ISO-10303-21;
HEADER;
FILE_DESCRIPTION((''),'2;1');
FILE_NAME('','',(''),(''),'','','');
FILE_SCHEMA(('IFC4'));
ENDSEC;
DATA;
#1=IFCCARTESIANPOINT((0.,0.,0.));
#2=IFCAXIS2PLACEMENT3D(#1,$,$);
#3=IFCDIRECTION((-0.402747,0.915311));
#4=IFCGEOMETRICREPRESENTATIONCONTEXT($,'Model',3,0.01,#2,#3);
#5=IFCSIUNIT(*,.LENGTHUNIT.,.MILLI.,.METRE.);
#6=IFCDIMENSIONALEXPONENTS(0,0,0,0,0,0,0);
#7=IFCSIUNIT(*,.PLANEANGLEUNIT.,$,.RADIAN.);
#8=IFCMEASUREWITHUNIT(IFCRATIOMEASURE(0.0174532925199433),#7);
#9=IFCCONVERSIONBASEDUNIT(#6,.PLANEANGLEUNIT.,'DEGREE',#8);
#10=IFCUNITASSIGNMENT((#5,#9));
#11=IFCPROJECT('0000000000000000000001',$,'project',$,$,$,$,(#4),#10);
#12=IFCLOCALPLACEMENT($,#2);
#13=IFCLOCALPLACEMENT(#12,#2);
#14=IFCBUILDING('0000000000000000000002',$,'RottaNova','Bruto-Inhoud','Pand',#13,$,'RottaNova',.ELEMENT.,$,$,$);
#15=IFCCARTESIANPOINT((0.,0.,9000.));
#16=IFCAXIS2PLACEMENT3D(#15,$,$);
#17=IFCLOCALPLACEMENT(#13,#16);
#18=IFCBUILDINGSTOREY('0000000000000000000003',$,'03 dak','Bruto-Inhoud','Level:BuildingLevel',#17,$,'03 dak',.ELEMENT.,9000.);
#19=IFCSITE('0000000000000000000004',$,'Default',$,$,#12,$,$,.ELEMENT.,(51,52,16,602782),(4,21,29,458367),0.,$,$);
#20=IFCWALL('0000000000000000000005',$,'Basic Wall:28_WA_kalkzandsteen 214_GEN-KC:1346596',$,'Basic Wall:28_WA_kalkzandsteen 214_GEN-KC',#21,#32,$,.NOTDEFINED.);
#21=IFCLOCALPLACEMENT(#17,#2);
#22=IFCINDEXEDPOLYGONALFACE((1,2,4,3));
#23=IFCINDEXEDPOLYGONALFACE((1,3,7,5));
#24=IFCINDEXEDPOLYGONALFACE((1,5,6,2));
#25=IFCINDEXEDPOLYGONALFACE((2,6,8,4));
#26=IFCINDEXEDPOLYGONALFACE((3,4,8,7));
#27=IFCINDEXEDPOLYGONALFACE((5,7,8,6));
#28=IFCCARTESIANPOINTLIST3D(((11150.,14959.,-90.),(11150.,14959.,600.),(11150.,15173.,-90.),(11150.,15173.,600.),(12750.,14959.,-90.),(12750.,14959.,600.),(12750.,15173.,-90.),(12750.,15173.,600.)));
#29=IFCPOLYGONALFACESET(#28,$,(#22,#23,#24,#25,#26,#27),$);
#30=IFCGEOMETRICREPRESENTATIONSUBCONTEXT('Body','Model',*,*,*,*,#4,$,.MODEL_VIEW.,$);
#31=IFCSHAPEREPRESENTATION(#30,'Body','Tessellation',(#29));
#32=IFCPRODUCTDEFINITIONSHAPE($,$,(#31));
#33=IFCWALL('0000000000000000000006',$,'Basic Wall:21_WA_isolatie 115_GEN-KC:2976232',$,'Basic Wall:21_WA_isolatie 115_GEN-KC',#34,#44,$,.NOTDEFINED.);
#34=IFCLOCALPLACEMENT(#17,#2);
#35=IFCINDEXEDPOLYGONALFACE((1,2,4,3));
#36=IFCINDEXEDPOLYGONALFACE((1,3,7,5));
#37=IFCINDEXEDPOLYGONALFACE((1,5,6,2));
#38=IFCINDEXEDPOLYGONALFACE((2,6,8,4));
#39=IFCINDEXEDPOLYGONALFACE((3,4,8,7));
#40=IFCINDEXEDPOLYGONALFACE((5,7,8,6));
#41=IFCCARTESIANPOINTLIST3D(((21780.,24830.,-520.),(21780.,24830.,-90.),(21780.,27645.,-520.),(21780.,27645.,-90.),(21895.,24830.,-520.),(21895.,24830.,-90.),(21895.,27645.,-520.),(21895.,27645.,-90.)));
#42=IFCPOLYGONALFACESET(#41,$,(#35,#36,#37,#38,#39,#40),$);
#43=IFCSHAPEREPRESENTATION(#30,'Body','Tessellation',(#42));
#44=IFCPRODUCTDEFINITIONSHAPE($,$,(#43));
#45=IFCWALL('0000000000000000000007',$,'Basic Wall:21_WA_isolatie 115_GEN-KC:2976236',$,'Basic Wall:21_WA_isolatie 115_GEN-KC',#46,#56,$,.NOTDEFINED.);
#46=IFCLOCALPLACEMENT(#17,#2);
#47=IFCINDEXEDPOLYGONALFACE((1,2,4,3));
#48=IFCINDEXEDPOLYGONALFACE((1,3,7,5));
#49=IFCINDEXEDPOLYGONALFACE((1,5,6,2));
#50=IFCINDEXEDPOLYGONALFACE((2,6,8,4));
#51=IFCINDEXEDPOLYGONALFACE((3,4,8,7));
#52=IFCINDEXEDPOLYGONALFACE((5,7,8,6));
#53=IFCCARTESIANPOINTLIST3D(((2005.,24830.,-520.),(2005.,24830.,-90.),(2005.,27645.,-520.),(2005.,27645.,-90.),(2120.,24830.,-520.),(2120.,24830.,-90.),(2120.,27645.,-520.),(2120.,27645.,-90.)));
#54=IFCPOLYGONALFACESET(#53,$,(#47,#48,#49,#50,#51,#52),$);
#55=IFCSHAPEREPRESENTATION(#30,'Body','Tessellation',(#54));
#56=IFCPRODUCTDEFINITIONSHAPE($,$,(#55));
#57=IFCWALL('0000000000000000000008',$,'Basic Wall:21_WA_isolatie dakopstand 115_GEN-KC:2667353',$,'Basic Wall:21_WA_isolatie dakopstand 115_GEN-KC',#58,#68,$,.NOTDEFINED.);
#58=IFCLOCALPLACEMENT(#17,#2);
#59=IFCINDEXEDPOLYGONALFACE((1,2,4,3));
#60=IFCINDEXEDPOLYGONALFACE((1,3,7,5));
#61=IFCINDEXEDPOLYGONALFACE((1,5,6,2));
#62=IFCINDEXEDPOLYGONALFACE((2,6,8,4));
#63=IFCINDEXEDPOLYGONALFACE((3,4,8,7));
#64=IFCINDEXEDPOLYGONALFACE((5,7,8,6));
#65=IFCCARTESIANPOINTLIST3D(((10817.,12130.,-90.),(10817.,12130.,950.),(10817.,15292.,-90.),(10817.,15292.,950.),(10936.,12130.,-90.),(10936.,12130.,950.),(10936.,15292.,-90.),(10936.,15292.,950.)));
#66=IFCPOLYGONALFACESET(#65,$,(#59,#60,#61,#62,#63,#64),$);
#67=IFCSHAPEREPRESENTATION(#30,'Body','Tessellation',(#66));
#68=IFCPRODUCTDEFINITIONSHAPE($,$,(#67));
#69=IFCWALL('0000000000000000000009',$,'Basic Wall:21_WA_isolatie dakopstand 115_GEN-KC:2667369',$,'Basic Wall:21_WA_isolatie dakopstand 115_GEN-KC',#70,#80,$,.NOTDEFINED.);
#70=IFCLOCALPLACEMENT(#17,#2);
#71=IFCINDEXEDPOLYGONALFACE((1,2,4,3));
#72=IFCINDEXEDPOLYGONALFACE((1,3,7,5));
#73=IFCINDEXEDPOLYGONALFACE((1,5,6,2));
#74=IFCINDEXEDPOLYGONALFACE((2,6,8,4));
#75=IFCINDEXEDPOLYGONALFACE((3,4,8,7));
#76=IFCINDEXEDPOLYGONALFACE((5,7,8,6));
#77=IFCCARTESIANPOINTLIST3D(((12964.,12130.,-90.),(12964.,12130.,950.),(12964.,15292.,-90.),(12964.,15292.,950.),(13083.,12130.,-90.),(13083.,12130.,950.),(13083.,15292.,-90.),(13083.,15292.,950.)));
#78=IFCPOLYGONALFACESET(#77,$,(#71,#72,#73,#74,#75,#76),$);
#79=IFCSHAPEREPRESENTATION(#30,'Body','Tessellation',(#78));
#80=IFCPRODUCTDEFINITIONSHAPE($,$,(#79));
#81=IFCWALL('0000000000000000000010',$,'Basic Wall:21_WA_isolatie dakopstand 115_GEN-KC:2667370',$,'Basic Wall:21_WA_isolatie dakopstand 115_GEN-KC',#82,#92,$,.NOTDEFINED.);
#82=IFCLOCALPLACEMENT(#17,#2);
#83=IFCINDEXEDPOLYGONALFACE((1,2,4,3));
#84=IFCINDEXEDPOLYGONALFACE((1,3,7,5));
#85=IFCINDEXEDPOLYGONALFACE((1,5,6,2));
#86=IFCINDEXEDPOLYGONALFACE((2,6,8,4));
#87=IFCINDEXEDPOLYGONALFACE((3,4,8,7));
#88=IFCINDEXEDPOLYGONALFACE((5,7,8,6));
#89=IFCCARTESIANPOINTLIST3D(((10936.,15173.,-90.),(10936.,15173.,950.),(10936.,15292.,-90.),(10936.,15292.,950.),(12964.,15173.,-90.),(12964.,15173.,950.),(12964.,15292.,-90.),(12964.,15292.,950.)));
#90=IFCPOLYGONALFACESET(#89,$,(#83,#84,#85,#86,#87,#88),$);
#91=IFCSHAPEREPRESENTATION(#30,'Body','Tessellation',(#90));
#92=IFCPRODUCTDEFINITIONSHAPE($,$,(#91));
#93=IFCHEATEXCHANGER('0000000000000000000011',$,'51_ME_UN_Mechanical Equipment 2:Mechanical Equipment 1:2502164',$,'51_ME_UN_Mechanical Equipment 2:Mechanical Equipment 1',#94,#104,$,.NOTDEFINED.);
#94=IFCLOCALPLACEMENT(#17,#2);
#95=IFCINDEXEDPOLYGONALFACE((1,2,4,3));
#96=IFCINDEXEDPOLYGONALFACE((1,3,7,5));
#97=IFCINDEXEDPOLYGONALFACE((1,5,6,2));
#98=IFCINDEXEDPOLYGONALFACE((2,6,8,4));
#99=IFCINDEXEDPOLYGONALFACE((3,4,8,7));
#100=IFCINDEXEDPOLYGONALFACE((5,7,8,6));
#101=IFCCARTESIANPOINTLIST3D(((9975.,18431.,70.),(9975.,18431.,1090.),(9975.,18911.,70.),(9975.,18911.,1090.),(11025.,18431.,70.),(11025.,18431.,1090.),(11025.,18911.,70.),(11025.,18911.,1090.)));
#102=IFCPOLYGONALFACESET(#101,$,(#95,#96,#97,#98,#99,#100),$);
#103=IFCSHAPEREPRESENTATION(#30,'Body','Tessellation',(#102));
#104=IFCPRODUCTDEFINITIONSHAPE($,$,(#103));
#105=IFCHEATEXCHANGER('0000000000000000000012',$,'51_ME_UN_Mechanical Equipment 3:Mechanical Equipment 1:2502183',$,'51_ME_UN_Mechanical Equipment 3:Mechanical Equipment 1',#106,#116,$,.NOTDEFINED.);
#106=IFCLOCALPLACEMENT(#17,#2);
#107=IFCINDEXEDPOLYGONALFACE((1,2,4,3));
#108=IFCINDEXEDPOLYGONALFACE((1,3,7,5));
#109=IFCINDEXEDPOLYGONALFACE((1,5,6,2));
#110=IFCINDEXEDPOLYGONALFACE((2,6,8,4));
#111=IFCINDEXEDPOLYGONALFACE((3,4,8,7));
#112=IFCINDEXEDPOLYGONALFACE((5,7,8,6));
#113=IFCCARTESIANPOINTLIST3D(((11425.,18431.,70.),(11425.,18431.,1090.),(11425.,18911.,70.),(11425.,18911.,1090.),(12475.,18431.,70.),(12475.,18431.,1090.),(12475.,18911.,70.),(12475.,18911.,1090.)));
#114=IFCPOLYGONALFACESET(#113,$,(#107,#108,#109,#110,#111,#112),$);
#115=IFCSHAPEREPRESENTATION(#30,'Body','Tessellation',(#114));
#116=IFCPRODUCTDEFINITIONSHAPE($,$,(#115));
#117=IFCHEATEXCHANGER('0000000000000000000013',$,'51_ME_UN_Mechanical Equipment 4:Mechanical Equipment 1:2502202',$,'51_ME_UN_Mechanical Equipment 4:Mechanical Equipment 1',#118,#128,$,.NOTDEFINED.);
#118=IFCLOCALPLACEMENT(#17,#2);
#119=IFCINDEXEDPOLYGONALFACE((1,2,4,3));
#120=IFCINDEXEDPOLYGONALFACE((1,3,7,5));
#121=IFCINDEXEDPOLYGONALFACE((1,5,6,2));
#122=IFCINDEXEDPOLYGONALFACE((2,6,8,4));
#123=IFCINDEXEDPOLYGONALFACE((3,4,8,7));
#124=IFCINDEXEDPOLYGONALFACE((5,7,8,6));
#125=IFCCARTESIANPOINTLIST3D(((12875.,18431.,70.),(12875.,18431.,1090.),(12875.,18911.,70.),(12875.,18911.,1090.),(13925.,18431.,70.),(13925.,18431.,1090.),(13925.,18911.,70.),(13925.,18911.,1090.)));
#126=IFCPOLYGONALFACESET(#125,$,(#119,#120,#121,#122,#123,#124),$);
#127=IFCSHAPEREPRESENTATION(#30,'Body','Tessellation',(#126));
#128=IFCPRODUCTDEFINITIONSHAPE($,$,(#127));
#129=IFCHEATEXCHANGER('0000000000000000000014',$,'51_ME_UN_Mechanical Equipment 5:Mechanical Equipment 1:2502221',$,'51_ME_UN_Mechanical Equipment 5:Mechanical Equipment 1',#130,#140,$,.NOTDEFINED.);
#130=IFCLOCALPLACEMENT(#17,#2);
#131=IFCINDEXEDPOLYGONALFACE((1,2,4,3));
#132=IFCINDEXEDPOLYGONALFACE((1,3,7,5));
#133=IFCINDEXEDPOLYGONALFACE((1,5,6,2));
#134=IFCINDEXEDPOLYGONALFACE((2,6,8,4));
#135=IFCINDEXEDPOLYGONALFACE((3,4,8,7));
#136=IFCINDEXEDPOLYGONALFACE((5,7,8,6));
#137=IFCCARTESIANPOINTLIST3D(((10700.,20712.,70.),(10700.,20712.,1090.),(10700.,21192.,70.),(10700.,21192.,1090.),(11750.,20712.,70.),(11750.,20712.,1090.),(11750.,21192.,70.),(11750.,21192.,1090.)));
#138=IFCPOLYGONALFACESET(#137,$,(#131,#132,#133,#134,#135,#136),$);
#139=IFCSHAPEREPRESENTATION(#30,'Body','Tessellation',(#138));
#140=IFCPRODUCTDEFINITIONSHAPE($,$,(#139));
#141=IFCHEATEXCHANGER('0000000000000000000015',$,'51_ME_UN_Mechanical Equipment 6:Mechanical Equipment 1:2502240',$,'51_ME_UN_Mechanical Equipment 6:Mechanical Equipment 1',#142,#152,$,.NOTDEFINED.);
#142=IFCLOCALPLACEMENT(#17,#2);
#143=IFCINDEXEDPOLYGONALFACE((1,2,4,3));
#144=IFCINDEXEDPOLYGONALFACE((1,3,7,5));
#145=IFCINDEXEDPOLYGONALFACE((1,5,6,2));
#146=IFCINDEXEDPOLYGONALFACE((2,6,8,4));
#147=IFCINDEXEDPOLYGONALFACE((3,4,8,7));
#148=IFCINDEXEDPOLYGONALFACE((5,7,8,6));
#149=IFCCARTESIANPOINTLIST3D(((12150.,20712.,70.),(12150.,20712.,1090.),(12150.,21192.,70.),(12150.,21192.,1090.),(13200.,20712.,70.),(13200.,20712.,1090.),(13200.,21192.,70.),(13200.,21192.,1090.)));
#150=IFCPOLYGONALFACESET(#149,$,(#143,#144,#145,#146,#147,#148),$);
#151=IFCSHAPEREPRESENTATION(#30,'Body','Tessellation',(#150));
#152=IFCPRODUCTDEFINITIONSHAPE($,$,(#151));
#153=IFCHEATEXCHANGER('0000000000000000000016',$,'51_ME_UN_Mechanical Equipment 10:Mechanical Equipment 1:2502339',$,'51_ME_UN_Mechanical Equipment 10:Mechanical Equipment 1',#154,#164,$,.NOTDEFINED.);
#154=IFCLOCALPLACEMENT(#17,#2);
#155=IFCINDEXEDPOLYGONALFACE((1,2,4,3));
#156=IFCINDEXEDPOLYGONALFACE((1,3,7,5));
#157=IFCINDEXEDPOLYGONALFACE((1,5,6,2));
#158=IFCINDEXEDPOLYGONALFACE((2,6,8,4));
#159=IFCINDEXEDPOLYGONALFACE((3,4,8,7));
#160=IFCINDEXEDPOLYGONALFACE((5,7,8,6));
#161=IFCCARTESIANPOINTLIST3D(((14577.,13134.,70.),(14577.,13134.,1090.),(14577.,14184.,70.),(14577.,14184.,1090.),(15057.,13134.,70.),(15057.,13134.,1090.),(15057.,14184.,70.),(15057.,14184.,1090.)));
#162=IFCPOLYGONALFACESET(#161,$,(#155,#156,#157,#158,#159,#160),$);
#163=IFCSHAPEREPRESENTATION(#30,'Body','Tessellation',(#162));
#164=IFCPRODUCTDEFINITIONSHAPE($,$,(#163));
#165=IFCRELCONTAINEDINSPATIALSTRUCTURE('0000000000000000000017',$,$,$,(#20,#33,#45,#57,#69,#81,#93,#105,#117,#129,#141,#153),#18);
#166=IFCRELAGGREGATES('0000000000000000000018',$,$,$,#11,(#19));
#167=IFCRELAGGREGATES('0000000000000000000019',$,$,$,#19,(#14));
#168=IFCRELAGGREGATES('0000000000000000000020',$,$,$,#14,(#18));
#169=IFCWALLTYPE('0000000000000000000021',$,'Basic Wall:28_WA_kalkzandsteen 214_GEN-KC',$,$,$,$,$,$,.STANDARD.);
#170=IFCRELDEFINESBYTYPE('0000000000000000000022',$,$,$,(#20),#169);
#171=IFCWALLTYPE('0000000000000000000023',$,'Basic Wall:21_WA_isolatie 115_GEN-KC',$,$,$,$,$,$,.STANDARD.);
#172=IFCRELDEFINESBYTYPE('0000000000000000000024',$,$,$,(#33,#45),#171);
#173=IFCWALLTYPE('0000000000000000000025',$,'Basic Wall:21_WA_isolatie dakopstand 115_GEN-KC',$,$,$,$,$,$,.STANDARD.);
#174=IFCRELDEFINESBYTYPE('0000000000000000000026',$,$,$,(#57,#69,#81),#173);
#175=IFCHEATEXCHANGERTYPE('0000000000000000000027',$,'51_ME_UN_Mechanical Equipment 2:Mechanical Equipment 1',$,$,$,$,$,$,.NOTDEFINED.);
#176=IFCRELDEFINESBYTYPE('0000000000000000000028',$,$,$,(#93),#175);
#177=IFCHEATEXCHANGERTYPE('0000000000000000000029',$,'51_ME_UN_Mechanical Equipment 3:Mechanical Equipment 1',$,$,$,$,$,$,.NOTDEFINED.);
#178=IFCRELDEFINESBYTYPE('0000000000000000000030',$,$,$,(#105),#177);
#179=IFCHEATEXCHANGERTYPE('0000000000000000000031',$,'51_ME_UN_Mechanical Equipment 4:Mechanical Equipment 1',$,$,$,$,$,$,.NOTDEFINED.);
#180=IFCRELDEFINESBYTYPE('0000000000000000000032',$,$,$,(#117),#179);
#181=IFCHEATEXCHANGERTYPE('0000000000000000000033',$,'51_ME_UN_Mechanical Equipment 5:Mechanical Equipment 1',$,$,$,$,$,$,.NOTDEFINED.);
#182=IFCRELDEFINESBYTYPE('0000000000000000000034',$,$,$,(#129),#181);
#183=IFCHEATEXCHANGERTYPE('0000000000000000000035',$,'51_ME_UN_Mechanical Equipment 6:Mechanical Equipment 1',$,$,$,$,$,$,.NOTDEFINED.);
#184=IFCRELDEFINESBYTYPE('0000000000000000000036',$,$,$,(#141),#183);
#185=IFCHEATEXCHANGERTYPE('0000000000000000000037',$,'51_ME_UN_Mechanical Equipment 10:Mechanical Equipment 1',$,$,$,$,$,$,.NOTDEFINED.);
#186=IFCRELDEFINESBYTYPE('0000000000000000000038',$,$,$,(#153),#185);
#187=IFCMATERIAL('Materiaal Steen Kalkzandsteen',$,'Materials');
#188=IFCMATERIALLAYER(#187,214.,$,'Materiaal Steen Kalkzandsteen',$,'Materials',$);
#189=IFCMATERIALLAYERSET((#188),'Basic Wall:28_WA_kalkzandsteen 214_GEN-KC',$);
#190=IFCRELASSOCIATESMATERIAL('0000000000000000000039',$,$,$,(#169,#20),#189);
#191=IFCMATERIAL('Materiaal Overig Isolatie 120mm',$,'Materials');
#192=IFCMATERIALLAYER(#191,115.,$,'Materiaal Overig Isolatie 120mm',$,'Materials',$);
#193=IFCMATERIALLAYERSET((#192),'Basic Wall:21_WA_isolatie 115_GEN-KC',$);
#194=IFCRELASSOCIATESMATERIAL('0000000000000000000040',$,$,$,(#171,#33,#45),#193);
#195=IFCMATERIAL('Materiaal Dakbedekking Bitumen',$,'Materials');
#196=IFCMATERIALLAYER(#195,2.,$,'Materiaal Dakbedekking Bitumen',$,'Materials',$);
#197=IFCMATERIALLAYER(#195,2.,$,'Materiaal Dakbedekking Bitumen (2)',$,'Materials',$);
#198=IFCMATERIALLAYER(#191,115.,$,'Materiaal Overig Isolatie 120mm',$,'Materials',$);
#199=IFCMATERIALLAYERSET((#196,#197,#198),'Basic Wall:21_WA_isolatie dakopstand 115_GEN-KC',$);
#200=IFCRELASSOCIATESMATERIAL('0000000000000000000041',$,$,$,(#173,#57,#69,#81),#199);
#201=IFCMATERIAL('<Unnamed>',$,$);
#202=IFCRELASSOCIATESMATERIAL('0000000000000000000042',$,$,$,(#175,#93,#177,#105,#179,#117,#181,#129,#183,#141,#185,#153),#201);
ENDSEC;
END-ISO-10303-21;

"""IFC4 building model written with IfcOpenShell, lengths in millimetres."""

from ifc_helpers import new_model, entity, si_unit, converted_unit, direction, frame, frame_2d, origin, place, context, subcontext, project, spatial, rectangle, extrude, source, transform, mapped, material, layer, layer_set, type_object, type_shapes, element, save


model = new_model("IFC4")

# Units and contexts
model_context = context("Model", 3, precision=0.01, world=origin(), true_north=direction((-0.402747, 0.915311)))
body_context = subcontext(model_context, "Body", "Model", "MODEL_VIEW")
ifc_project = project(units=[si_unit("LENGTHUNIT", "METRE", prefix="MILLI"), converted_unit("PLANEANGLEUNIT", "DEGREE", entity("IfcRatioMeasure", 0.0174532925199433), si_unit("PLANEANGLEUNIT", "RADIAN"), dimensions=[0, 0, 0, 0, 0, 0, 0])], contexts=[model_context])

# Site, building, storey
site_placement = place(None, origin())
site = spatial("IfcSite", under=ifc_project, at=site_placement, Name="Default", CompositionType="ELEMENT", RefLatitude=(51, 52, 16, 602782), RefLongitude=(4, 21, 29, 458367), RefElevation=0.0)
building_placement = place(site_placement, origin())
building = spatial("IfcBuilding", under=site, at=building_placement, Name="RottaNova", Description="Bruto-Inhoud", ObjectType="Pand", LongName="RottaNova", CompositionType="ELEMENT")
storey_placement = place(building_placement, frame((0.0, 0.0, 9000.0)))
storey = spatial("IfcBuildingStorey", under=building, at=storey_placement, Name="03 dak", Description="Bruto-Inhoud", ObjectType="Level:BuildingLevel", LongName="03 dak", CompositionType="ELEMENT", Elevation=9000.0)

# Wall
ifc_material_1 = material(Name="Materiaal Steen Kalkzandsteen", Category="Materials")
ifc_layer_1 = layer(ifc_material_1, 214.0, Name="Materiaal Steen Kalkzandsteen", Category="Materials")
ifc_layer_set_1 = layer_set([ifc_layer_1], Name="Basic Wall:28_WA_kalkzandsteen 214_GEN-KC")
wall_type_1 = type_object("IfcWallType", Name="Basic Wall:28_WA_kalkzandsteen 214_GEN-KC", PredefinedType="STANDARD", material=ifc_layer_set_1)
wall_1_placement = place(storey_placement, frame((11150.0, 15066.0, -90.0)))
element("IfcWall", 1, at=wall_1_placement, inside=storey, type_object=wall_type_1, material=ifc_layer_set_1, Name="Basic Wall:28_WA_kalkzandsteen 214_GEN-KC:1346596", ObjectType="Basic Wall:28_WA_kalkzandsteen 214_GEN-KC", PredefinedType="NOTDEFINED", context=body_context, shape_type="SweptSolid", body=[
    extrude(rectangle(XDim=1600.0, YDim=214.0, at=frame_2d((800.0, 0.0), x_axis=(-1.0, 0.0))), origin(), (0.0, 0.0, 1.0), 690.0),
])

# Shared definitions
ifc_material_2 = material(Name="Materiaal Overig Isolatie 120mm", Category="Materials")
ifc_layer_2 = layer(ifc_material_2, 115.0, Name="Materiaal Overig Isolatie 120mm", Category="Materials")
ifc_layer_set_2 = layer_set([ifc_layer_2], Name="Basic Wall:21_WA_isolatie 115_GEN-KC")
wall_type_2 = type_object("IfcWallType", Name="Basic Wall:21_WA_isolatie 115_GEN-KC", PredefinedType="STANDARD", material=ifc_layer_set_2)

# Wall
wall_2_placement = place(storey_placement, frame((21837.5, 24830.0, -520.0), z_axis=(0.0, 0.0, 1.0), x_axis=(0.0, 1.0, 0.0)))
element("IfcWall", 2, at=wall_2_placement, inside=storey, type_object=wall_type_2, material=ifc_layer_set_2, Name="Basic Wall:21_WA_isolatie 115_GEN-KC:2976232", ObjectType="Basic Wall:21_WA_isolatie 115_GEN-KC", PredefinedType="NOTDEFINED", context=body_context, shape_type="SweptSolid", body=[
    extrude(rectangle(XDim=2815.0, YDim=115.0, at=frame_2d((1407.5, 0.0), x_axis=(-1.0, 0.0))), origin(), (0.0, 0.0, 1.0), 430.0),
])

# Walls
wall_3_placement = place(storey_placement, frame((2062.5, 24830.0, -520.0), z_axis=(0.0, 0.0, 1.0), x_axis=(0.0, 1.0, 0.0)))
element("IfcWall", 3, at=wall_3_placement, inside=storey, type_object=wall_type_2, material=ifc_layer_set_2, Name="Basic Wall:21_WA_isolatie 115_GEN-KC:2976236", ObjectType="Basic Wall:21_WA_isolatie 115_GEN-KC", PredefinedType="NOTDEFINED", context=body_context, shape_type="SweptSolid", body=[
    extrude(rectangle(XDim=2815.0, YDim=115.0, at=frame_2d((1407.5, 0.0), x_axis=(-1.0, 0.0))), origin(), (0.0, 0.0, 1.0), 430.0),
])
ifc_material_3 = material(Name="Materiaal Dakbedekking Bitumen", Category="Materials")
ifc_layer_3 = layer(ifc_material_3, 2.0, Name="Materiaal Dakbedekking Bitumen", Category="Materials")
ifc_layer_4 = layer(ifc_material_3, 2.0, Name="Materiaal Dakbedekking Bitumen (2)", Category="Materials")
ifc_layer_5 = layer(ifc_material_2, 115.0, Name="Materiaal Overig Isolatie 120mm", Category="Materials")
ifc_layer_set_3 = layer_set([ifc_layer_3, ifc_layer_4, ifc_layer_5], Name="Basic Wall:21_WA_isolatie dakopstand 115_GEN-KC")
wall_type_3 = type_object("IfcWallType", Name="Basic Wall:21_WA_isolatie dakopstand 115_GEN-KC", PredefinedType="STANDARD", material=ifc_layer_set_3)
wall_4_placement = place(storey_placement, frame((10876.5, 15292.0, -90.0), z_axis=(0.0, 0.0, 1.0), x_axis=(0.0, -1.0, 0.0)))
element("IfcWall", 4, at=wall_4_placement, inside=storey, type_object=wall_type_3, material=ifc_layer_set_3, Name="Basic Wall:21_WA_isolatie dakopstand 115_GEN-KC:2667353", ObjectType="Basic Wall:21_WA_isolatie dakopstand 115_GEN-KC", PredefinedType="NOTDEFINED", context=body_context, shape_type="SweptSolid", body=[
    extrude(rectangle(XDim=3162.0, YDim=119.0, at=frame_2d((1581.0, 0.0), x_axis=(-1.0, 0.0))), origin(), (0.0, 0.0, 1.0), 1040.0),
])
wall_5_placement = place(storey_placement, frame((13023.5, 15292.0, -90.0), z_axis=(0.0, 0.0, 1.0), x_axis=(0.0, -1.0, 0.0)))
element("IfcWall", 5, at=wall_5_placement, inside=storey, type_object=wall_type_3, material=ifc_layer_set_3, Name="Basic Wall:21_WA_isolatie dakopstand 115_GEN-KC:2667369", ObjectType="Basic Wall:21_WA_isolatie dakopstand 115_GEN-KC", PredefinedType="NOTDEFINED", context=body_context, shape_type="SweptSolid", body=[
    extrude(rectangle(XDim=3162.0, YDim=119.0, at=frame_2d((1581.0, 0.0), x_axis=(-1.0, 0.0))), origin(), (0.0, 0.0, 1.0), 1040.0),
])
wall_6_placement = place(storey_placement, frame((10936.0, 15232.5, -90.0)))
element("IfcWall", 6, at=wall_6_placement, inside=storey, type_object=wall_type_3, material=ifc_layer_set_3, Name="Basic Wall:21_WA_isolatie dakopstand 115_GEN-KC:2667370", ObjectType="Basic Wall:21_WA_isolatie dakopstand 115_GEN-KC", PredefinedType="NOTDEFINED", context=body_context, shape_type="SweptSolid", body=[
    extrude(rectangle(XDim=2028.0, YDim=119.0, at=frame_2d((1014.0, 0.0), x_axis=(-1.0, 0.0))), origin(), (0.0, 0.0, 1.0), 1040.0),
])

# Heat exchangers
ifc_material_4 = material(Name="<Unnamed>")
heat_exchanger_type_1 = type_object("IfcHeatExchangerType", Name="51_ME_UN_Mechanical Equipment 2:Mechanical Equipment 1", PredefinedType="NOTDEFINED", material=ifc_material_4)
shared_shape_1 = source(origin(), body_context, "Body", "SweptSolid", [
    extrude(rectangle(XDim=1050.0, YDim=480.0, at=frame_2d((0.0, 0.0), x_axis=(1.0, 0.0))), frame((525.0, 240.0, 0.0), z_axis=(0.0, 0.0, 1.0), x_axis=(-1.0, 0.0, 0.0)), (0.0, 0.0, 1.0), 1020.0),
])
type_shapes(heat_exchanger_type_1, [shared_shape_1])
heat_exchanger_1_placement = place(storey_placement, frame((9975.0, 18431.0, 70.0)))
element("IfcHeatExchanger", 7, at=heat_exchanger_1_placement, inside=storey, type_object=heat_exchanger_type_1, material=ifc_material_4, Name="51_ME_UN_Mechanical Equipment 2:Mechanical Equipment 1:2502164", ObjectType="51_ME_UN_Mechanical Equipment 2:Mechanical Equipment 1", PredefinedType="NOTDEFINED", context=body_context, shape_type="MappedRepresentation", body=[
    mapped(shared_shape_1, transform((0.0, 0.0, 0.0), scale=1.0)),
])
heat_exchanger_type_2 = type_object("IfcHeatExchangerType", Name="51_ME_UN_Mechanical Equipment 3:Mechanical Equipment 1", PredefinedType="NOTDEFINED", material=ifc_material_4)
shared_shape_2 = source(origin(), body_context, "Body", "SweptSolid", [
    extrude(rectangle(XDim=1050.0, YDim=480.0, at=frame_2d((0.0, 0.0), x_axis=(1.0, 0.0))), frame((525.0, 240.0, 0.0), z_axis=(0.0, 0.0, 1.0), x_axis=(-1.0, 0.0, 0.0)), (0.0, 0.0, 1.0), 1020.0),
])
type_shapes(heat_exchanger_type_2, [shared_shape_2])
heat_exchanger_2_placement = place(storey_placement, frame((11425.0, 18431.0, 70.0)))
element("IfcHeatExchanger", 8, at=heat_exchanger_2_placement, inside=storey, type_object=heat_exchanger_type_2, material=ifc_material_4, Name="51_ME_UN_Mechanical Equipment 3:Mechanical Equipment 1:2502183", ObjectType="51_ME_UN_Mechanical Equipment 3:Mechanical Equipment 1", PredefinedType="NOTDEFINED", context=body_context, shape_type="MappedRepresentation", body=[
    mapped(shared_shape_2, transform((0.0, 0.0, 0.0), scale=1.0)),
])
heat_exchanger_type_3 = type_object("IfcHeatExchangerType", Name="51_ME_UN_Mechanical Equipment 4:Mechanical Equipment 1", PredefinedType="NOTDEFINED", material=ifc_material_4)
shared_shape_3 = source(origin(), body_context, "Body", "SweptSolid", [
    extrude(rectangle(XDim=1050.0, YDim=480.0, at=frame_2d((0.0, 0.0), x_axis=(1.0, 0.0))), frame((525.0, 240.0, 0.0), z_axis=(0.0, 0.0, 1.0), x_axis=(-1.0, 0.0, 0.0)), (0.0, 0.0, 1.0), 1020.0),
])
type_shapes(heat_exchanger_type_3, [shared_shape_3])
heat_exchanger_3_placement = place(storey_placement, frame((12875.0, 18431.0, 70.0)))
element("IfcHeatExchanger", 9, at=heat_exchanger_3_placement, inside=storey, type_object=heat_exchanger_type_3, material=ifc_material_4, Name="51_ME_UN_Mechanical Equipment 4:Mechanical Equipment 1:2502202", ObjectType="51_ME_UN_Mechanical Equipment 4:Mechanical Equipment 1", PredefinedType="NOTDEFINED", context=body_context, shape_type="MappedRepresentation", body=[
    mapped(shared_shape_3, transform((0.0, 0.0, 0.0), scale=1.0)),
])
heat_exchanger_type_4 = type_object("IfcHeatExchangerType", Name="51_ME_UN_Mechanical Equipment 5:Mechanical Equipment 1", PredefinedType="NOTDEFINED", material=ifc_material_4)
shared_shape_4 = source(origin(), body_context, "Body", "SweptSolid", [
    extrude(rectangle(XDim=1050.0, YDim=480.0, at=frame_2d((0.0, 0.0), x_axis=(1.0, 0.0))), frame((525.0, 240.0, 0.0), z_axis=(0.0, 0.0, 1.0), x_axis=(-1.0, 0.0, 0.0)), (0.0, 0.0, 1.0), 1020.0),
])
type_shapes(heat_exchanger_type_4, [shared_shape_4])
heat_exchanger_4_placement = place(storey_placement, frame((10700.0, 20712.0, 70.0)))
element("IfcHeatExchanger", 10, at=heat_exchanger_4_placement, inside=storey, type_object=heat_exchanger_type_4, material=ifc_material_4, Name="51_ME_UN_Mechanical Equipment 5:Mechanical Equipment 1:2502221", ObjectType="51_ME_UN_Mechanical Equipment 5:Mechanical Equipment 1", PredefinedType="NOTDEFINED", context=body_context, shape_type="MappedRepresentation", body=[
    mapped(shared_shape_4, transform((0.0, 0.0, 0.0), scale=1.0)),
])
heat_exchanger_type_5 = type_object("IfcHeatExchangerType", Name="51_ME_UN_Mechanical Equipment 6:Mechanical Equipment 1", PredefinedType="NOTDEFINED", material=ifc_material_4)
shared_shape_5 = source(origin(), body_context, "Body", "SweptSolid", [
    extrude(rectangle(XDim=1050.0, YDim=480.0, at=frame_2d((0.0, 0.0), x_axis=(1.0, 0.0))), frame((525.0, 240.0, 0.0), z_axis=(0.0, 0.0, 1.0), x_axis=(-1.0, 0.0, 0.0)), (0.0, 0.0, 1.0), 1020.0),
])
type_shapes(heat_exchanger_type_5, [shared_shape_5])
heat_exchanger_5_placement = place(storey_placement, frame((12150.0, 20712.0, 70.0)))
element("IfcHeatExchanger", 11, at=heat_exchanger_5_placement, inside=storey, type_object=heat_exchanger_type_5, material=ifc_material_4, Name="51_ME_UN_Mechanical Equipment 6:Mechanical Equipment 1:2502240", ObjectType="51_ME_UN_Mechanical Equipment 6:Mechanical Equipment 1", PredefinedType="NOTDEFINED", context=body_context, shape_type="MappedRepresentation", body=[
    mapped(shared_shape_5, transform((0.0, 0.0, 0.0), scale=1.0)),
])
heat_exchanger_type_6 = type_object("IfcHeatExchangerType", Name="51_ME_UN_Mechanical Equipment 10:Mechanical Equipment 1", PredefinedType="NOTDEFINED", material=ifc_material_4)
shared_shape_6 = source(origin(), body_context, "Body", "SweptSolid", [
    extrude(rectangle(XDim=1050.0, YDim=480.0, at=frame_2d((0.0, 0.0), x_axis=(1.0, 0.0))), frame((525.0, 240.0, 0.0), z_axis=(0.0, 0.0, 1.0), x_axis=(-1.0, 0.0, 0.0)), (0.0, 0.0, 1.0), 1020.0),
])
type_shapes(heat_exchanger_type_6, [shared_shape_6])
heat_exchanger_6_placement = place(storey_placement, frame((15057.0, 13134.0, 70.0), z_axis=(0.0, 0.0, 1.0), x_axis=(0.0, 1.0, 0.0)))
element("IfcHeatExchanger", 12, at=heat_exchanger_6_placement, inside=storey, type_object=heat_exchanger_type_6, material=ifc_material_4, Name="51_ME_UN_Mechanical Equipment 10:Mechanical Equipment 1:2502339", ObjectType="51_ME_UN_Mechanical Equipment 10:Mechanical Equipment 1", PredefinedType="NOTDEFINED", context=body_context, shape_type="MappedRepresentation", body=[
    mapped(shared_shape_6, transform((0.0, 0.0, 0.0), scale=1.0)),
])

save(model, "model.ifc")
